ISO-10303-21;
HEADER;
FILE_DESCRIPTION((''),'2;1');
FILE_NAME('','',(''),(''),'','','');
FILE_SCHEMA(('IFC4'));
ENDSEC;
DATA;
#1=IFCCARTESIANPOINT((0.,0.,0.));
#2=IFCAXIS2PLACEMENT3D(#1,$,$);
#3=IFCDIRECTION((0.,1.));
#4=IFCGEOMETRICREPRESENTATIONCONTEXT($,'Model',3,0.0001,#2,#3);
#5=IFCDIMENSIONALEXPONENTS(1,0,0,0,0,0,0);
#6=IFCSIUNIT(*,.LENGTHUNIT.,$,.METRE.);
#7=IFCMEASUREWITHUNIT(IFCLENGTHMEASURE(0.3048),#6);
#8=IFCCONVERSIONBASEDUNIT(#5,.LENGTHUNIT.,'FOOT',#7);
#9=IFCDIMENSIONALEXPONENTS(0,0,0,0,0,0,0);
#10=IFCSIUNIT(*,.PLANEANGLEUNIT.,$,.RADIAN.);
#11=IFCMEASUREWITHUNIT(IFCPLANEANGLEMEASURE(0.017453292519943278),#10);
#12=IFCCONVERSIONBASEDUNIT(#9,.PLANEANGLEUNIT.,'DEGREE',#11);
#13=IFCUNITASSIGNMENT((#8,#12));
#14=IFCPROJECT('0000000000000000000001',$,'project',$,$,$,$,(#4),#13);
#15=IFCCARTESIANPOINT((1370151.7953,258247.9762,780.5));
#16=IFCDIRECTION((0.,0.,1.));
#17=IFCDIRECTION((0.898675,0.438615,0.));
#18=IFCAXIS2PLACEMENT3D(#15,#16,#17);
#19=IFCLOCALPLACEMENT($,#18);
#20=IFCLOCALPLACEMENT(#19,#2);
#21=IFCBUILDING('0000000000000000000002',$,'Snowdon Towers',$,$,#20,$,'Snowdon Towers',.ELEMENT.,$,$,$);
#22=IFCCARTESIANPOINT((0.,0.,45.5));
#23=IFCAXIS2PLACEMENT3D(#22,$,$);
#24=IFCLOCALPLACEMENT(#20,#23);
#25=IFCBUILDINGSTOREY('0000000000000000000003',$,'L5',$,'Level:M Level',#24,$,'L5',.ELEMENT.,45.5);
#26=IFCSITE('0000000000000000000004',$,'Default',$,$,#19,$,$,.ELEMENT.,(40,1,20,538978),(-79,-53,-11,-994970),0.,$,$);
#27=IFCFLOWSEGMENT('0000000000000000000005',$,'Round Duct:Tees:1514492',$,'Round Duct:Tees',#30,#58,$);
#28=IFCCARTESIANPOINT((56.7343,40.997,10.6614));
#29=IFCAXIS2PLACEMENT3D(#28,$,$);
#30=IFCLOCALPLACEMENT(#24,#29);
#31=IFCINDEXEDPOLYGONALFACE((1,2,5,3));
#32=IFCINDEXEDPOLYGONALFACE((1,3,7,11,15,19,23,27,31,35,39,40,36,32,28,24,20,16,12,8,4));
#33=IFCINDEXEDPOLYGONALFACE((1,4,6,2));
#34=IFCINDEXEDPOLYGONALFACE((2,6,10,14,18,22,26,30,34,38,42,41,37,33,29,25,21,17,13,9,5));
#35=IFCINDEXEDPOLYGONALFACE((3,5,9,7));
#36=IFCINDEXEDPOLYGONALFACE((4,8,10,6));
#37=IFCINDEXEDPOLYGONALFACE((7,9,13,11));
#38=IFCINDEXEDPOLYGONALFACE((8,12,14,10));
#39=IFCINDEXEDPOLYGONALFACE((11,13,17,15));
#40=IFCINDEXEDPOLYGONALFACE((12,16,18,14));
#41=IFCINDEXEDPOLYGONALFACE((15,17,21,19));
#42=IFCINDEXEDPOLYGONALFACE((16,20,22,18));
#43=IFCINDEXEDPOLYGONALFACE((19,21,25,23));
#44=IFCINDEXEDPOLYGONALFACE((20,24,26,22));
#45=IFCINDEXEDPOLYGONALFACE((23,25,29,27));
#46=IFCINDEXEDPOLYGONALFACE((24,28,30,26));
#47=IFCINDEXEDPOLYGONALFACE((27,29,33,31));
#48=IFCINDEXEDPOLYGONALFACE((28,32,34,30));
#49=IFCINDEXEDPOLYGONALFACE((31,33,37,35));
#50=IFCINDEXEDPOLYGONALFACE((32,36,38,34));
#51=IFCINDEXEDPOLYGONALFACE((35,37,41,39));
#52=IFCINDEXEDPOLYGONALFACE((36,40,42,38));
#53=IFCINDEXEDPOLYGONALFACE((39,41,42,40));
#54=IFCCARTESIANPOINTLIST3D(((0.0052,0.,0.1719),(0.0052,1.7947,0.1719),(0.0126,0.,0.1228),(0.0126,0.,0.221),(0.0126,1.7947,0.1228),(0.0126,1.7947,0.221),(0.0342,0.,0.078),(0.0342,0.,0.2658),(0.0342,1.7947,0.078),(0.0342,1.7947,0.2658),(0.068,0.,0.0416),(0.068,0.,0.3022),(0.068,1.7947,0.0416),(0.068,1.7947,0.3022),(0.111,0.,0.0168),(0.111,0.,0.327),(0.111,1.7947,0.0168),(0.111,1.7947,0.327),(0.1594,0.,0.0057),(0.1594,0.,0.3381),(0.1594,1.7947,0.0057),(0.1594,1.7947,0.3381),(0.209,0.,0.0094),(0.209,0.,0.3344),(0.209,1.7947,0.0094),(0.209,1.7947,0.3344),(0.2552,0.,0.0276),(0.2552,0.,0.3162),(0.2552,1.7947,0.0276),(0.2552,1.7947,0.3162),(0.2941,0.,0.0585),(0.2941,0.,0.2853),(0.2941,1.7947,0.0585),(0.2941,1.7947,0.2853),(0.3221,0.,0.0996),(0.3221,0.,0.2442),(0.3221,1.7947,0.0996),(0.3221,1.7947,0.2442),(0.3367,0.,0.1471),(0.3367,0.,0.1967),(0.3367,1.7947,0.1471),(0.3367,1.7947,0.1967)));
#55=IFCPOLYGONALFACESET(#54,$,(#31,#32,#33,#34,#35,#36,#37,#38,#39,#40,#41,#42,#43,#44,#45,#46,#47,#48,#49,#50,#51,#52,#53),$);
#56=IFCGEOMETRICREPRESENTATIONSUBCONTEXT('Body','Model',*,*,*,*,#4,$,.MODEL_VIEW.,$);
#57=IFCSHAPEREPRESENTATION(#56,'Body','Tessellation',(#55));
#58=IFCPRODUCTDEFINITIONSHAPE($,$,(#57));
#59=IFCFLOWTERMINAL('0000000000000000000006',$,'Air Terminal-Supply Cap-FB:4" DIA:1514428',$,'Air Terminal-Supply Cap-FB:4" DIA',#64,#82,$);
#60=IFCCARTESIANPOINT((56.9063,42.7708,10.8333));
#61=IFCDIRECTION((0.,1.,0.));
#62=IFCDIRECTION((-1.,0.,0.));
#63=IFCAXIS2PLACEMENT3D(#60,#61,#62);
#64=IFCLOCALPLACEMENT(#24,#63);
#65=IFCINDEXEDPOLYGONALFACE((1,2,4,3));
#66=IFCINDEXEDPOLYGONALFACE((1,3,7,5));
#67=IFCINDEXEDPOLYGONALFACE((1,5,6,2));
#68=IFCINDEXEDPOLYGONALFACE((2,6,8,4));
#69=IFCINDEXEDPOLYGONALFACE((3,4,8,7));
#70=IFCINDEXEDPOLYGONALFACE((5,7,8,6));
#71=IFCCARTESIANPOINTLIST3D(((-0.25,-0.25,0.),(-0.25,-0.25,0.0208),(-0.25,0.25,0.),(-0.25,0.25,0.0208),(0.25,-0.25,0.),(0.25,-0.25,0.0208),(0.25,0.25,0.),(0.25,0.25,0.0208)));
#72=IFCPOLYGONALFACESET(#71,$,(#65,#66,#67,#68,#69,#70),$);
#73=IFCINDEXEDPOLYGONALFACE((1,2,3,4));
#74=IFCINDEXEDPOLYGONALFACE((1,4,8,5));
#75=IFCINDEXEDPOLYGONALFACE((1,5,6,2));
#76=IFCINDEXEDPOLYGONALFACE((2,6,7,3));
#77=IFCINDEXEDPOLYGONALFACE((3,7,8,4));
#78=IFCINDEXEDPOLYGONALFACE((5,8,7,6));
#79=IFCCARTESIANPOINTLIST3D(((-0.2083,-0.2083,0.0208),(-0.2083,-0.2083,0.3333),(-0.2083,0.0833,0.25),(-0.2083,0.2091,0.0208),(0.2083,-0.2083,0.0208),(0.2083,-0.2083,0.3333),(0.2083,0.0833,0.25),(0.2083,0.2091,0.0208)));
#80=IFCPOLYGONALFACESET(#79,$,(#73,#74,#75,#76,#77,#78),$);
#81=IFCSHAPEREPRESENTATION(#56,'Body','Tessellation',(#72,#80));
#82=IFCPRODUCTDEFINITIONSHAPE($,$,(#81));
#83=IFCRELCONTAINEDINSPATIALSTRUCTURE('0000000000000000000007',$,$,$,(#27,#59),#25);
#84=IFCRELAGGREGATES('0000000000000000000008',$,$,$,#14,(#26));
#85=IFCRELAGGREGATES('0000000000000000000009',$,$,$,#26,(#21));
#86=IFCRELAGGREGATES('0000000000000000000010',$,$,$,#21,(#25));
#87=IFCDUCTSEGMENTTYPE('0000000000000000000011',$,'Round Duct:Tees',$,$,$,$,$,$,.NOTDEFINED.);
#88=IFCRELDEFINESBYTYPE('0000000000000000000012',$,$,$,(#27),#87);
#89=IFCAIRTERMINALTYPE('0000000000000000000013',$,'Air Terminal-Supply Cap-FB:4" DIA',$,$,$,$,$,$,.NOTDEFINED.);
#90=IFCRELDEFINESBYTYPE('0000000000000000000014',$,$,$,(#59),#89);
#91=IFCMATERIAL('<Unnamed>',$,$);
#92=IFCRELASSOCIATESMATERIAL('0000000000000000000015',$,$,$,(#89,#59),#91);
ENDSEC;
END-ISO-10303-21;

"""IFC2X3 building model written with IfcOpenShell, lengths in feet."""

from ifc_helpers import new_model, entity, si_unit, converted_unit, direction, frame, frame_2d, origin, origin_2d_with_axis, place, context, subcontext, project, spatial, polyline, rectangle, circle, outline, extrude, source, transform, mapped, material, type_object, type_shapes, element, save


model = new_model("IFC2X3")

# Units and contexts
model_context = context("Model", 3, precision=0.0001, world=origin(), true_north=direction((0.0, 1.0)))
body_context = subcontext(model_context, "Body", "Model", "MODEL_VIEW")
ifc_project = project(units=[converted_unit("LENGTHUNIT", "FOOT", entity("IfcLengthMeasure", 0.3048), si_unit("LENGTHUNIT", "METRE"), dimensions=[1, 0, 0, 0, 0, 0, 0]), converted_unit("PLANEANGLEUNIT", "DEGREE", entity("IfcPlaneAngleMeasure", 0.017453292519943278), si_unit("PLANEANGLEUNIT", "RADIAN"), dimensions=[0, 0, 0, 0, 0, 0, 0])], contexts=[model_context])

# Site, building, storey
site_placement = place(None, frame((1370151.7953, 258247.9762, 780.5), z_axis=(0.0, 0.0, 1.0), x_axis=(0.898675, 0.438615, 0.0)))
site = spatial("IfcSite", under=ifc_project, at=site_placement, Name="Default", CompositionType="ELEMENT", RefLatitude=(40, 1, 20, 538978), RefLongitude=(-79, -53, -11, -994970), RefElevation=0.0)
building_placement = place(site_placement, origin())
building = spatial("IfcBuilding", under=site, at=building_placement, Name="Snowdon Towers", LongName="Snowdon Towers", CompositionType="ELEMENT")
storey_placement = place(building_placement, frame((0.0, 0.0, 45.5)))
storey = spatial("IfcBuildingStorey", under=building, at=storey_placement, Name="L5", ObjectType="Level:M Level", LongName="L5", CompositionType="ELEMENT", Elevation=45.5)

# Flow segment
duct_segment_type = type_object("IfcDuctSegmentType", Name="Round Duct:Tees", PredefinedType="NOTDEFINED")
flow_segment_1_placement = place(storey_placement, frame((56.7343, 40.997, 10.6614)))
element("IfcFlowSegment", 1, at=flow_segment_1_placement, inside=storey, type_object=duct_segment_type, Name="Round Duct:Tees:1514492", ObjectType="Round Duct:Tees", context=body_context, shape_type="SweptSolid", body=[
    extrude(circle(Radius=0.1667, at=frame_2d((0.0, 0.0), x_axis=(1.0, 0.0))), frame((0.1719, 0.0, 0.1719), z_axis=(0.0, 1.0, 0.0), x_axis=(-1.0, 0.0, 0.0)), (0.0, 0.0, 1.0), 1.7947),
])

# Shared definitions
ifc_material = material(Name="<Unnamed>")

# Flow terminal
air_terminal_type = type_object("IfcAirTerminalType", Name="Air Terminal-Supply Cap-FB:4\" DIA", PredefinedType="NOTDEFINED", material=ifc_material)
shared_shape_1 = source(origin(), body_context, "Body", "SweptSolid", [
    extrude(rectangle(XDim=0.5, YDim=0.5, at=origin_2d_with_axis()), frame((0.0, 0.0, 0.0), z_axis=(0.0, 0.0, 1.0), x_axis=(-1.0, 0.0, 0.0)), (0.0, 0.0, 1.0), 0.0208),
    extrude(outline(polyline([(-0.1771, -0.1773), (0.1354, -0.1773), (0.1354, 0.2402), (-0.0938, 0.1144), (-0.1771, -0.1773)])), frame((-0.2083, -0.0311, 0.1562), z_axis=(1.0, 0.0, 0.0), x_axis=(0.0, 0.0, -1.0)), (0.0, 0.0, 1.0), 0.4167),
])
type_shapes(air_terminal_type, [shared_shape_1])
flow_terminal_placement = place(storey_placement, frame((56.9063, 42.7708, 10.8333), z_axis=(0.0, 1.0, 0.0), x_axis=(-1.0, 0.0, 0.0)))
element("IfcFlowTerminal", 2, at=flow_terminal_placement, inside=storey, type_object=air_terminal_type, material=ifc_material, Name="Air Terminal-Supply Cap-FB:4\" DIA:1514428", ObjectType="Air Terminal-Supply Cap-FB:4\" DIA", context=body_context, shape_type="MappedRepresentation", body=[
    mapped(shared_shape_1, transform((0.0, 0.0, 0.0), scale=1.0)),
])

save(model, "model.ifc")
